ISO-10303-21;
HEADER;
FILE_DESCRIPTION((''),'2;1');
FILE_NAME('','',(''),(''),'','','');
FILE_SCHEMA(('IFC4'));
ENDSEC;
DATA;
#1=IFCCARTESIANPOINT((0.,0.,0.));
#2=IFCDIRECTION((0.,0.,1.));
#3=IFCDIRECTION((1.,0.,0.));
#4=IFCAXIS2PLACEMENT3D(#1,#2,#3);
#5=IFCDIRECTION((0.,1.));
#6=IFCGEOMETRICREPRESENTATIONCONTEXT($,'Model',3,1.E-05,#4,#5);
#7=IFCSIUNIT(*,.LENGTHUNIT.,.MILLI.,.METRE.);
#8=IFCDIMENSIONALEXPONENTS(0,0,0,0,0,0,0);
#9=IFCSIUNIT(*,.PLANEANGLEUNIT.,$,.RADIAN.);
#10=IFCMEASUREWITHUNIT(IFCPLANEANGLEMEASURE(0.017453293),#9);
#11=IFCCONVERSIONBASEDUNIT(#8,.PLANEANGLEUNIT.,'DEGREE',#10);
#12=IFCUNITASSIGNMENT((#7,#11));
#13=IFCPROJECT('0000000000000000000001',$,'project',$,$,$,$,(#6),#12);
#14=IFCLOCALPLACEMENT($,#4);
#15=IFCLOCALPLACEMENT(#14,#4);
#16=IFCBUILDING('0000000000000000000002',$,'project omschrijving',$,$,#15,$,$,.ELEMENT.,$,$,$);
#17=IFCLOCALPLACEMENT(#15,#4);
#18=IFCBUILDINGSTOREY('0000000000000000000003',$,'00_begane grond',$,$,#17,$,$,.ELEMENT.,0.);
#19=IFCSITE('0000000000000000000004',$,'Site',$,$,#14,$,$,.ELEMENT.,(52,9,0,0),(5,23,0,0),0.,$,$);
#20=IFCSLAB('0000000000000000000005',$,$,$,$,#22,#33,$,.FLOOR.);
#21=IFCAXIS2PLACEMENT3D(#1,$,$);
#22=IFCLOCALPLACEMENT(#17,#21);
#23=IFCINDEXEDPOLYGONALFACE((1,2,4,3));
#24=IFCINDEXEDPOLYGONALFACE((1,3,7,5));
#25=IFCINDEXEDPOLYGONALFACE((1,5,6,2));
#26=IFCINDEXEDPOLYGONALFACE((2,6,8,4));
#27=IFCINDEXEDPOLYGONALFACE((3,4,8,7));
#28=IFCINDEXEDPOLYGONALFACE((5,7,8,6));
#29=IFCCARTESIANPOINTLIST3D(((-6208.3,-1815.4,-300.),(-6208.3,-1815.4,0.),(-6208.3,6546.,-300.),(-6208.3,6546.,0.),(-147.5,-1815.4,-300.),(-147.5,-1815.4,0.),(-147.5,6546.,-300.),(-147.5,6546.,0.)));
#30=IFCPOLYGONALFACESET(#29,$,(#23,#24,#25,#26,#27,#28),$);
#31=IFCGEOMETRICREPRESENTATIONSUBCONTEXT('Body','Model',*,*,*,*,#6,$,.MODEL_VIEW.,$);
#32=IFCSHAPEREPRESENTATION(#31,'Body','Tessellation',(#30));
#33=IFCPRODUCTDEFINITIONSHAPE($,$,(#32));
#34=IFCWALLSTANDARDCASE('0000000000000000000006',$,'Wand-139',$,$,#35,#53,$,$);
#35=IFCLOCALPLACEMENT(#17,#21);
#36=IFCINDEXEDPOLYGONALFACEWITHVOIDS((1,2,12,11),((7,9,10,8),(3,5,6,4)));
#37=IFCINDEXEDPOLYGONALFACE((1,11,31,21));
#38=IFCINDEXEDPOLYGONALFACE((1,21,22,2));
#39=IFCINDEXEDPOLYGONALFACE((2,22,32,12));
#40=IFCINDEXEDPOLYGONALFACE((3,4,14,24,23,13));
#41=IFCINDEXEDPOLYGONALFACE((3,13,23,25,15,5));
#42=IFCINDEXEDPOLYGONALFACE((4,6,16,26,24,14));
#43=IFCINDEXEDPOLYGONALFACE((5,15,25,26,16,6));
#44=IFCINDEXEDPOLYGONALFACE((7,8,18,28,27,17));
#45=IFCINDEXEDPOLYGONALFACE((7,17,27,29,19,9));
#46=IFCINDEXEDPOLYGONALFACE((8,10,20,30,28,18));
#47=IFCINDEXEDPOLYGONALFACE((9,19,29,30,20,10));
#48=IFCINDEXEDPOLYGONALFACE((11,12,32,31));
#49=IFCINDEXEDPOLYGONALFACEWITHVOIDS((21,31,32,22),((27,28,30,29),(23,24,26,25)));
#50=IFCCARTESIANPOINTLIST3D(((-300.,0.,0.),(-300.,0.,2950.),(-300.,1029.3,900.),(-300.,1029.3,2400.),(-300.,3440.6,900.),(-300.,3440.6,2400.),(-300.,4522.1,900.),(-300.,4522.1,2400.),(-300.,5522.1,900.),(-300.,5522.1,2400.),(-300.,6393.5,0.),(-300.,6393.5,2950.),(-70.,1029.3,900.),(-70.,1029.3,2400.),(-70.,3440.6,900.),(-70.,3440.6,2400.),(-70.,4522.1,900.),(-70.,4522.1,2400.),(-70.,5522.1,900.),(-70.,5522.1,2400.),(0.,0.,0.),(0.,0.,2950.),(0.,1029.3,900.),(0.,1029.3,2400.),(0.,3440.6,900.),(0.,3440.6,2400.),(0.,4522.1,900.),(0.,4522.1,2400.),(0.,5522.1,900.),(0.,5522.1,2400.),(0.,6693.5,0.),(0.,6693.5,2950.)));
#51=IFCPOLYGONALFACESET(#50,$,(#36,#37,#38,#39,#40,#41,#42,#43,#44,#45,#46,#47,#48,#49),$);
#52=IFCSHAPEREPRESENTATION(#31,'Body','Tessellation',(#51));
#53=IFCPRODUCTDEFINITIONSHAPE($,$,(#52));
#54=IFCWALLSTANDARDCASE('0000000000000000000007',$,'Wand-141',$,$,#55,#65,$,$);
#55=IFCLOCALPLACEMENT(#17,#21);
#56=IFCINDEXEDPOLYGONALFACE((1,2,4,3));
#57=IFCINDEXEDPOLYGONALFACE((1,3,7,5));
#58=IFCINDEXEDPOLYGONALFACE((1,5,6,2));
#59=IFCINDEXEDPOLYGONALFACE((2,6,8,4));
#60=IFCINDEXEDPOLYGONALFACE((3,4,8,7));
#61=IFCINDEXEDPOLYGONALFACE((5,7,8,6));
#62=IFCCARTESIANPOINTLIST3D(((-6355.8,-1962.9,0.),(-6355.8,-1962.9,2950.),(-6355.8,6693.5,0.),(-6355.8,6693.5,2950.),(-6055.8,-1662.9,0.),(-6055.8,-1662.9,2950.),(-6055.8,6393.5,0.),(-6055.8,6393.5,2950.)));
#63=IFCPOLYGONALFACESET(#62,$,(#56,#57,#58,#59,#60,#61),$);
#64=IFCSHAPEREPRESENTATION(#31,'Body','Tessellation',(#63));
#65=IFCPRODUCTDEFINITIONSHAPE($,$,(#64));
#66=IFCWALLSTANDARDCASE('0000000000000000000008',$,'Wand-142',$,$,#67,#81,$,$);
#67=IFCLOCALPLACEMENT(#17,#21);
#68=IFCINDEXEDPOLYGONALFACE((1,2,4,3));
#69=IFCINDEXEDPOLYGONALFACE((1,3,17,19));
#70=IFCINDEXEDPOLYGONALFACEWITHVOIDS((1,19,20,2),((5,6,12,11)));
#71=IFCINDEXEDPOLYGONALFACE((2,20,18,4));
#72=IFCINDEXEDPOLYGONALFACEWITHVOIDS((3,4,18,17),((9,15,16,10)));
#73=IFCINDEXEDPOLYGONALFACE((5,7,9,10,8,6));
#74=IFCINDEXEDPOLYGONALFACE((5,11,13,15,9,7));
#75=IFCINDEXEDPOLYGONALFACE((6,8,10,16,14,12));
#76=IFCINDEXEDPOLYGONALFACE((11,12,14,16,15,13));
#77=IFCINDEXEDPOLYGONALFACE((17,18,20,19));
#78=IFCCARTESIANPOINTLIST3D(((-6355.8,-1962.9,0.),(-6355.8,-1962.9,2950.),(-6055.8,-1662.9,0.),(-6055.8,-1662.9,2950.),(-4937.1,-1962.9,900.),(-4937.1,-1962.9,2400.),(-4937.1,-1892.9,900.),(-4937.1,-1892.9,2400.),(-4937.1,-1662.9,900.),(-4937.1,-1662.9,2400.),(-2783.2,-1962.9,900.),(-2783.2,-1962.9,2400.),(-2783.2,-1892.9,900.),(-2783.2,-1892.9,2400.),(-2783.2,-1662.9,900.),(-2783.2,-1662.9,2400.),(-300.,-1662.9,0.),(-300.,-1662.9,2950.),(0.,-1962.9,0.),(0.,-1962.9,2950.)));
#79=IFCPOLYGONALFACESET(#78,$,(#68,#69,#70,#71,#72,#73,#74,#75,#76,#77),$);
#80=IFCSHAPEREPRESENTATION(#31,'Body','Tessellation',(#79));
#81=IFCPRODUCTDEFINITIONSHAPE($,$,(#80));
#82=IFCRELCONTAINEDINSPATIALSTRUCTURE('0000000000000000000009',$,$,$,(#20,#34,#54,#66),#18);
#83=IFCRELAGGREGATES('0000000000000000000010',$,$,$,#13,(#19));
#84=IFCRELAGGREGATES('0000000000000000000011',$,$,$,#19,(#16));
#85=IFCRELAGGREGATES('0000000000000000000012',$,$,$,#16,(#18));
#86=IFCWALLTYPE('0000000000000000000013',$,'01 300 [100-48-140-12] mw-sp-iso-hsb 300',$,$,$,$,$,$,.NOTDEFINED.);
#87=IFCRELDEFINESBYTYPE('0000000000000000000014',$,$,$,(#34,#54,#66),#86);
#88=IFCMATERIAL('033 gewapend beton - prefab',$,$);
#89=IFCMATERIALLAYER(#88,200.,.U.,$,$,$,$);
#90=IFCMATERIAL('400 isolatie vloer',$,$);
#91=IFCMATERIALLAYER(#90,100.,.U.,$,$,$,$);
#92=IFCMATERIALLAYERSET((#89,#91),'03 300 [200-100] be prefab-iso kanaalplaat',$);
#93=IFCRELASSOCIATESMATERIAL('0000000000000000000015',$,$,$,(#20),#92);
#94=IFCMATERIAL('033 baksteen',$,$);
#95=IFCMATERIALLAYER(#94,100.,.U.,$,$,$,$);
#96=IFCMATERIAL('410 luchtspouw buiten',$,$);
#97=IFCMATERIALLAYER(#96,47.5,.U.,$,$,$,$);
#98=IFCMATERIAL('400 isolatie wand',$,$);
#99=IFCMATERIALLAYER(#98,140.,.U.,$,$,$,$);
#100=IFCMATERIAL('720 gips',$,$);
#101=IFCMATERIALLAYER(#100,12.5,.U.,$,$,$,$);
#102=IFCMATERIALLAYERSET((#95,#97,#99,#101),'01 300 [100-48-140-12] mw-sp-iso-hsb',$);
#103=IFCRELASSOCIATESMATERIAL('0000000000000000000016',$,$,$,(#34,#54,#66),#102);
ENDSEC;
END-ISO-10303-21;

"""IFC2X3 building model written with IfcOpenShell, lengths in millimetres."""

from ifc_helpers import new_model, entity, si_unit, converted_unit, direction, frame, origin_with_axes, origin_2d_with_axis, place, context, subcontext, project, spatial, polyline, rectangle, outline, extrude, material, layer, layer_set, layer_usage, type_object, element, save


model = new_model("IFC2X3")

# Units and contexts
model_context = context("Model", 3, precision=1e-05, world=origin_with_axes(), true_north=direction((0.0, 1.0)))
body_context = subcontext(model_context, "Body", "Model", "MODEL_VIEW")
ifc_project = project(units=[si_unit("LENGTHUNIT", "METRE", prefix="MILLI"), converted_unit("PLANEANGLEUNIT", "DEGREE", entity("IfcPlaneAngleMeasure", 0.017453293), si_unit("PLANEANGLEUNIT", "RADIAN"), dimensions=[0, 0, 0, 0, 0, 0, 0])], contexts=[model_context])

# Site, building, storey
site_placement = place(None, origin_with_axes())
site = spatial("IfcSite", under=ifc_project, at=site_placement, Name="Site", CompositionType="ELEMENT", RefLatitude=(52, 9, 0, 0), RefLongitude=(5, 23, 0, 0), RefElevation=0.0)
building_placement = place(site_placement, origin_with_axes())
building = spatial("IfcBuilding", under=site, at=building_placement, Name="project omschrijving", CompositionType="ELEMENT")
storey_placement = place(building_placement, origin_with_axes())
storey = spatial("IfcBuildingStorey", under=building, at=storey_placement, Name="00_begane grond", CompositionType="ELEMENT", Elevation=0.0)

# Slab
ifc_material_1 = material(Name="033 gewapend beton - prefab")
ifc_layer_1 = layer(ifc_material_1, 200.0, ventilated="UNKNOWN")
ifc_material_2 = material(Name="400 isolatie vloer")
ifc_layer_2 = layer(ifc_material_2, 100.0, ventilated="UNKNOWN")
ifc_layer_set_1 = layer_set([ifc_layer_1, ifc_layer_2], Name="03 300 [200-100] be prefab-iso kanaalplaat")
ifc_layer_usage_1 = layer_usage(ifc_layer_set_1, "AXIS3", "NEGATIVE", 300.0)
slab_placement = place(storey_placement, frame((-6208.3, 6546.0, -300.0), z_axis=(0.0, 0.0, 1.0), x_axis=(1.0, 0.0, 0.0)))
element("IfcSlab", 1, at=slab_placement, inside=storey, material=ifc_layer_usage_1, PredefinedType="FLOOR", context=body_context, shape_type="SweptSolid", body=[
    extrude(outline(polyline([(0.0, 0.0), (0.0, -8361.4), (6060.8, -8361.4), (6060.8, 0.0), (0.0, 0.0)])), origin_with_axes(), (0.0, 0.0, 1.0), 300.0),
])

# Shared definitions
ifc_material_3 = material(Name="033 baksteen")
ifc_layer_3 = layer(ifc_material_3, 100.0, ventilated="UNKNOWN")
ifc_material_4 = material(Name="410 luchtspouw buiten")
ifc_layer_4 = layer(ifc_material_4, 47.5, ventilated="UNKNOWN")
ifc_material_5 = material(Name="400 isolatie wand")
ifc_layer_5 = layer(ifc_material_5, 140.0, ventilated="UNKNOWN")
ifc_material_6 = material(Name="720 gips")
ifc_layer_6 = layer(ifc_material_6, 12.5, ventilated="UNKNOWN")
ifc_layer_set_2 = layer_set([ifc_layer_3, ifc_layer_4, ifc_layer_5, ifc_layer_6], Name="01 300 [100-48-140-12] mw-sp-iso-hsb")
wall_type = type_object("IfcWallType", Name="01 300 [100-48-140-12] mw-sp-iso-hsb 300", PredefinedType="NOTDEFINED")

# Wall, openings
ifc_layer_usage_2 = layer_usage(ifc_layer_set_2, "AXIS2", "POSITIVE", 0.0)
wall_1_placement = place(storey_placement, frame((0.0, 0.0, 0.0), z_axis=(0.0, 0.0, 1.0), x_axis=(0.0, 1.0, 0.0)))
wall_1 = element("IfcWallStandardCase", 2, at=wall_1_placement, inside=storey, type_object=wall_type, material=ifc_layer_usage_2, Name="Wand-139", context=body_context, shape_type="SweptSolid", body=[
    extrude(outline(polyline([(0.0, 0.0), (6693.5, 0.0), (6393.5, 300.0), (0.0, 300.0), (0.0, 0.0)])), origin_with_axes(), (0.0, 0.0, 1.0), 2950.0),
])
opening_1_placement = place(wall_1_placement, frame((5022.1, 0.0, 900.0), z_axis=(0.0, 0.0, 1.0), x_axis=(1.0, 0.0, 0.0)))
element("IfcOpeningElement", 3, at=opening_1_placement, cuts=wall_1, context=body_context, shape_type="SweptSolid", body=[
    extrude(rectangle(XDim=1000.0, YDim=1500.0, at=origin_2d_with_axis()), frame((0.0, 600.0, 750.0), z_axis=(0.0, 1.0, 0.0), x_axis=(1.0, 0.0, 0.0)), (0.0, 0.0, -1.0), 530.0),
    extrude(rectangle(XDim=1000.0, YDim=1500.0, at=origin_2d_with_axis()), frame((0.0, -300.0, 750.0), z_axis=(0.0, -1.0, 0.0), x_axis=(1.0, 0.0, 0.0)), (0.0, 0.0, -1.0), 370.0),
])
opening_2_placement = place(wall_1_placement, frame((2234.9, 0.0, 900.0), z_axis=(0.0, 0.0, 1.0), x_axis=(1.0, 0.0, 0.0)))
element("IfcOpeningElement", 4, at=opening_2_placement, cuts=wall_1, context=body_context, shape_type="SweptSolid", body=[
    extrude(rectangle(XDim=2411.3, YDim=1500.0, at=origin_2d_with_axis()), frame((0.0, 600.0, 750.0), z_axis=(0.0, 1.0, 0.0), x_axis=(1.0, 0.0, 0.0)), (0.0, 0.0, -1.0), 530.0),
    extrude(rectangle(XDim=2411.3, YDim=1500.0, at=origin_2d_with_axis()), frame((0.0, -300.0, 750.0), z_axis=(0.0, -1.0, 0.0), x_axis=(1.0, 0.0, 0.0)), (0.0, 0.0, -1.0), 370.0),
])

# Wall
ifc_layer_usage_3 = layer_usage(ifc_layer_set_2, "AXIS2", "POSITIVE", 0.0)
wall_2_placement = place(storey_placement, frame((-6355.8, 6693.5, 0.0), z_axis=(0.0, 0.0, 1.0), x_axis=(0.0, -1.0, 0.0)))
element("IfcWallStandardCase", 5, at=wall_2_placement, inside=storey, type_object=wall_type, material=ifc_layer_usage_3, Name="Wand-141", context=body_context, shape_type="SweptSolid", body=[
    extrude(outline(polyline([(0.0, 0.0), (8656.4, 0.0), (8356.4, 300.0), (300.0, 300.0), (0.0, 0.0)])), origin_with_axes(), (0.0, 0.0, 1.0), 2950.0),
])

# Wall, opening
ifc_layer_usage_4 = layer_usage(ifc_layer_set_2, "AXIS2", "POSITIVE", 0.0)
wall_3_placement = place(storey_placement, frame((-6355.8, -1962.9, 0.0), z_axis=(0.0, 0.0, 1.0), x_axis=(1.0, 0.0, 0.0)))
wall_3 = element("IfcWallStandardCase", 6, at=wall_3_placement, inside=storey, type_object=wall_type, material=ifc_layer_usage_4, Name="Wand-142", context=body_context, shape_type="SweptSolid", body=[
    extrude(outline(polyline([(0.0, 0.0), (6355.8, 0.0), (6055.8, 300.0), (300.0, 300.0), (0.0, 0.0)])), origin_with_axes(), (0.0, 0.0, 1.0), 2950.0),
])
opening_3_placement = place(wall_3_placement, frame((2495.6, 0.0, 900.0), z_axis=(0.0, 0.0, 1.0), x_axis=(1.0, 0.0, 0.0)))
element("IfcOpeningElement", 7, at=opening_3_placement, cuts=wall_3, context=body_context, shape_type="SweptSolid", body=[
    extrude(rectangle(XDim=2154.0, YDim=1500.0, at=origin_2d_with_axis()), frame((0.0, 600.0, 750.0), z_axis=(0.0, 1.0, 0.0), x_axis=(1.0, 0.0, 0.0)), (0.0, 0.0, -1.0), 530.0),
    extrude(rectangle(XDim=2154.0, YDim=1500.0, at=origin_2d_with_axis()), frame((0.0, -300.0, 750.0), z_axis=(0.0, -1.0, 0.0), x_axis=(1.0, 0.0, 0.0)), (0.0, 0.0, -1.0), 370.0),
])

save(model, "model.ifc")
